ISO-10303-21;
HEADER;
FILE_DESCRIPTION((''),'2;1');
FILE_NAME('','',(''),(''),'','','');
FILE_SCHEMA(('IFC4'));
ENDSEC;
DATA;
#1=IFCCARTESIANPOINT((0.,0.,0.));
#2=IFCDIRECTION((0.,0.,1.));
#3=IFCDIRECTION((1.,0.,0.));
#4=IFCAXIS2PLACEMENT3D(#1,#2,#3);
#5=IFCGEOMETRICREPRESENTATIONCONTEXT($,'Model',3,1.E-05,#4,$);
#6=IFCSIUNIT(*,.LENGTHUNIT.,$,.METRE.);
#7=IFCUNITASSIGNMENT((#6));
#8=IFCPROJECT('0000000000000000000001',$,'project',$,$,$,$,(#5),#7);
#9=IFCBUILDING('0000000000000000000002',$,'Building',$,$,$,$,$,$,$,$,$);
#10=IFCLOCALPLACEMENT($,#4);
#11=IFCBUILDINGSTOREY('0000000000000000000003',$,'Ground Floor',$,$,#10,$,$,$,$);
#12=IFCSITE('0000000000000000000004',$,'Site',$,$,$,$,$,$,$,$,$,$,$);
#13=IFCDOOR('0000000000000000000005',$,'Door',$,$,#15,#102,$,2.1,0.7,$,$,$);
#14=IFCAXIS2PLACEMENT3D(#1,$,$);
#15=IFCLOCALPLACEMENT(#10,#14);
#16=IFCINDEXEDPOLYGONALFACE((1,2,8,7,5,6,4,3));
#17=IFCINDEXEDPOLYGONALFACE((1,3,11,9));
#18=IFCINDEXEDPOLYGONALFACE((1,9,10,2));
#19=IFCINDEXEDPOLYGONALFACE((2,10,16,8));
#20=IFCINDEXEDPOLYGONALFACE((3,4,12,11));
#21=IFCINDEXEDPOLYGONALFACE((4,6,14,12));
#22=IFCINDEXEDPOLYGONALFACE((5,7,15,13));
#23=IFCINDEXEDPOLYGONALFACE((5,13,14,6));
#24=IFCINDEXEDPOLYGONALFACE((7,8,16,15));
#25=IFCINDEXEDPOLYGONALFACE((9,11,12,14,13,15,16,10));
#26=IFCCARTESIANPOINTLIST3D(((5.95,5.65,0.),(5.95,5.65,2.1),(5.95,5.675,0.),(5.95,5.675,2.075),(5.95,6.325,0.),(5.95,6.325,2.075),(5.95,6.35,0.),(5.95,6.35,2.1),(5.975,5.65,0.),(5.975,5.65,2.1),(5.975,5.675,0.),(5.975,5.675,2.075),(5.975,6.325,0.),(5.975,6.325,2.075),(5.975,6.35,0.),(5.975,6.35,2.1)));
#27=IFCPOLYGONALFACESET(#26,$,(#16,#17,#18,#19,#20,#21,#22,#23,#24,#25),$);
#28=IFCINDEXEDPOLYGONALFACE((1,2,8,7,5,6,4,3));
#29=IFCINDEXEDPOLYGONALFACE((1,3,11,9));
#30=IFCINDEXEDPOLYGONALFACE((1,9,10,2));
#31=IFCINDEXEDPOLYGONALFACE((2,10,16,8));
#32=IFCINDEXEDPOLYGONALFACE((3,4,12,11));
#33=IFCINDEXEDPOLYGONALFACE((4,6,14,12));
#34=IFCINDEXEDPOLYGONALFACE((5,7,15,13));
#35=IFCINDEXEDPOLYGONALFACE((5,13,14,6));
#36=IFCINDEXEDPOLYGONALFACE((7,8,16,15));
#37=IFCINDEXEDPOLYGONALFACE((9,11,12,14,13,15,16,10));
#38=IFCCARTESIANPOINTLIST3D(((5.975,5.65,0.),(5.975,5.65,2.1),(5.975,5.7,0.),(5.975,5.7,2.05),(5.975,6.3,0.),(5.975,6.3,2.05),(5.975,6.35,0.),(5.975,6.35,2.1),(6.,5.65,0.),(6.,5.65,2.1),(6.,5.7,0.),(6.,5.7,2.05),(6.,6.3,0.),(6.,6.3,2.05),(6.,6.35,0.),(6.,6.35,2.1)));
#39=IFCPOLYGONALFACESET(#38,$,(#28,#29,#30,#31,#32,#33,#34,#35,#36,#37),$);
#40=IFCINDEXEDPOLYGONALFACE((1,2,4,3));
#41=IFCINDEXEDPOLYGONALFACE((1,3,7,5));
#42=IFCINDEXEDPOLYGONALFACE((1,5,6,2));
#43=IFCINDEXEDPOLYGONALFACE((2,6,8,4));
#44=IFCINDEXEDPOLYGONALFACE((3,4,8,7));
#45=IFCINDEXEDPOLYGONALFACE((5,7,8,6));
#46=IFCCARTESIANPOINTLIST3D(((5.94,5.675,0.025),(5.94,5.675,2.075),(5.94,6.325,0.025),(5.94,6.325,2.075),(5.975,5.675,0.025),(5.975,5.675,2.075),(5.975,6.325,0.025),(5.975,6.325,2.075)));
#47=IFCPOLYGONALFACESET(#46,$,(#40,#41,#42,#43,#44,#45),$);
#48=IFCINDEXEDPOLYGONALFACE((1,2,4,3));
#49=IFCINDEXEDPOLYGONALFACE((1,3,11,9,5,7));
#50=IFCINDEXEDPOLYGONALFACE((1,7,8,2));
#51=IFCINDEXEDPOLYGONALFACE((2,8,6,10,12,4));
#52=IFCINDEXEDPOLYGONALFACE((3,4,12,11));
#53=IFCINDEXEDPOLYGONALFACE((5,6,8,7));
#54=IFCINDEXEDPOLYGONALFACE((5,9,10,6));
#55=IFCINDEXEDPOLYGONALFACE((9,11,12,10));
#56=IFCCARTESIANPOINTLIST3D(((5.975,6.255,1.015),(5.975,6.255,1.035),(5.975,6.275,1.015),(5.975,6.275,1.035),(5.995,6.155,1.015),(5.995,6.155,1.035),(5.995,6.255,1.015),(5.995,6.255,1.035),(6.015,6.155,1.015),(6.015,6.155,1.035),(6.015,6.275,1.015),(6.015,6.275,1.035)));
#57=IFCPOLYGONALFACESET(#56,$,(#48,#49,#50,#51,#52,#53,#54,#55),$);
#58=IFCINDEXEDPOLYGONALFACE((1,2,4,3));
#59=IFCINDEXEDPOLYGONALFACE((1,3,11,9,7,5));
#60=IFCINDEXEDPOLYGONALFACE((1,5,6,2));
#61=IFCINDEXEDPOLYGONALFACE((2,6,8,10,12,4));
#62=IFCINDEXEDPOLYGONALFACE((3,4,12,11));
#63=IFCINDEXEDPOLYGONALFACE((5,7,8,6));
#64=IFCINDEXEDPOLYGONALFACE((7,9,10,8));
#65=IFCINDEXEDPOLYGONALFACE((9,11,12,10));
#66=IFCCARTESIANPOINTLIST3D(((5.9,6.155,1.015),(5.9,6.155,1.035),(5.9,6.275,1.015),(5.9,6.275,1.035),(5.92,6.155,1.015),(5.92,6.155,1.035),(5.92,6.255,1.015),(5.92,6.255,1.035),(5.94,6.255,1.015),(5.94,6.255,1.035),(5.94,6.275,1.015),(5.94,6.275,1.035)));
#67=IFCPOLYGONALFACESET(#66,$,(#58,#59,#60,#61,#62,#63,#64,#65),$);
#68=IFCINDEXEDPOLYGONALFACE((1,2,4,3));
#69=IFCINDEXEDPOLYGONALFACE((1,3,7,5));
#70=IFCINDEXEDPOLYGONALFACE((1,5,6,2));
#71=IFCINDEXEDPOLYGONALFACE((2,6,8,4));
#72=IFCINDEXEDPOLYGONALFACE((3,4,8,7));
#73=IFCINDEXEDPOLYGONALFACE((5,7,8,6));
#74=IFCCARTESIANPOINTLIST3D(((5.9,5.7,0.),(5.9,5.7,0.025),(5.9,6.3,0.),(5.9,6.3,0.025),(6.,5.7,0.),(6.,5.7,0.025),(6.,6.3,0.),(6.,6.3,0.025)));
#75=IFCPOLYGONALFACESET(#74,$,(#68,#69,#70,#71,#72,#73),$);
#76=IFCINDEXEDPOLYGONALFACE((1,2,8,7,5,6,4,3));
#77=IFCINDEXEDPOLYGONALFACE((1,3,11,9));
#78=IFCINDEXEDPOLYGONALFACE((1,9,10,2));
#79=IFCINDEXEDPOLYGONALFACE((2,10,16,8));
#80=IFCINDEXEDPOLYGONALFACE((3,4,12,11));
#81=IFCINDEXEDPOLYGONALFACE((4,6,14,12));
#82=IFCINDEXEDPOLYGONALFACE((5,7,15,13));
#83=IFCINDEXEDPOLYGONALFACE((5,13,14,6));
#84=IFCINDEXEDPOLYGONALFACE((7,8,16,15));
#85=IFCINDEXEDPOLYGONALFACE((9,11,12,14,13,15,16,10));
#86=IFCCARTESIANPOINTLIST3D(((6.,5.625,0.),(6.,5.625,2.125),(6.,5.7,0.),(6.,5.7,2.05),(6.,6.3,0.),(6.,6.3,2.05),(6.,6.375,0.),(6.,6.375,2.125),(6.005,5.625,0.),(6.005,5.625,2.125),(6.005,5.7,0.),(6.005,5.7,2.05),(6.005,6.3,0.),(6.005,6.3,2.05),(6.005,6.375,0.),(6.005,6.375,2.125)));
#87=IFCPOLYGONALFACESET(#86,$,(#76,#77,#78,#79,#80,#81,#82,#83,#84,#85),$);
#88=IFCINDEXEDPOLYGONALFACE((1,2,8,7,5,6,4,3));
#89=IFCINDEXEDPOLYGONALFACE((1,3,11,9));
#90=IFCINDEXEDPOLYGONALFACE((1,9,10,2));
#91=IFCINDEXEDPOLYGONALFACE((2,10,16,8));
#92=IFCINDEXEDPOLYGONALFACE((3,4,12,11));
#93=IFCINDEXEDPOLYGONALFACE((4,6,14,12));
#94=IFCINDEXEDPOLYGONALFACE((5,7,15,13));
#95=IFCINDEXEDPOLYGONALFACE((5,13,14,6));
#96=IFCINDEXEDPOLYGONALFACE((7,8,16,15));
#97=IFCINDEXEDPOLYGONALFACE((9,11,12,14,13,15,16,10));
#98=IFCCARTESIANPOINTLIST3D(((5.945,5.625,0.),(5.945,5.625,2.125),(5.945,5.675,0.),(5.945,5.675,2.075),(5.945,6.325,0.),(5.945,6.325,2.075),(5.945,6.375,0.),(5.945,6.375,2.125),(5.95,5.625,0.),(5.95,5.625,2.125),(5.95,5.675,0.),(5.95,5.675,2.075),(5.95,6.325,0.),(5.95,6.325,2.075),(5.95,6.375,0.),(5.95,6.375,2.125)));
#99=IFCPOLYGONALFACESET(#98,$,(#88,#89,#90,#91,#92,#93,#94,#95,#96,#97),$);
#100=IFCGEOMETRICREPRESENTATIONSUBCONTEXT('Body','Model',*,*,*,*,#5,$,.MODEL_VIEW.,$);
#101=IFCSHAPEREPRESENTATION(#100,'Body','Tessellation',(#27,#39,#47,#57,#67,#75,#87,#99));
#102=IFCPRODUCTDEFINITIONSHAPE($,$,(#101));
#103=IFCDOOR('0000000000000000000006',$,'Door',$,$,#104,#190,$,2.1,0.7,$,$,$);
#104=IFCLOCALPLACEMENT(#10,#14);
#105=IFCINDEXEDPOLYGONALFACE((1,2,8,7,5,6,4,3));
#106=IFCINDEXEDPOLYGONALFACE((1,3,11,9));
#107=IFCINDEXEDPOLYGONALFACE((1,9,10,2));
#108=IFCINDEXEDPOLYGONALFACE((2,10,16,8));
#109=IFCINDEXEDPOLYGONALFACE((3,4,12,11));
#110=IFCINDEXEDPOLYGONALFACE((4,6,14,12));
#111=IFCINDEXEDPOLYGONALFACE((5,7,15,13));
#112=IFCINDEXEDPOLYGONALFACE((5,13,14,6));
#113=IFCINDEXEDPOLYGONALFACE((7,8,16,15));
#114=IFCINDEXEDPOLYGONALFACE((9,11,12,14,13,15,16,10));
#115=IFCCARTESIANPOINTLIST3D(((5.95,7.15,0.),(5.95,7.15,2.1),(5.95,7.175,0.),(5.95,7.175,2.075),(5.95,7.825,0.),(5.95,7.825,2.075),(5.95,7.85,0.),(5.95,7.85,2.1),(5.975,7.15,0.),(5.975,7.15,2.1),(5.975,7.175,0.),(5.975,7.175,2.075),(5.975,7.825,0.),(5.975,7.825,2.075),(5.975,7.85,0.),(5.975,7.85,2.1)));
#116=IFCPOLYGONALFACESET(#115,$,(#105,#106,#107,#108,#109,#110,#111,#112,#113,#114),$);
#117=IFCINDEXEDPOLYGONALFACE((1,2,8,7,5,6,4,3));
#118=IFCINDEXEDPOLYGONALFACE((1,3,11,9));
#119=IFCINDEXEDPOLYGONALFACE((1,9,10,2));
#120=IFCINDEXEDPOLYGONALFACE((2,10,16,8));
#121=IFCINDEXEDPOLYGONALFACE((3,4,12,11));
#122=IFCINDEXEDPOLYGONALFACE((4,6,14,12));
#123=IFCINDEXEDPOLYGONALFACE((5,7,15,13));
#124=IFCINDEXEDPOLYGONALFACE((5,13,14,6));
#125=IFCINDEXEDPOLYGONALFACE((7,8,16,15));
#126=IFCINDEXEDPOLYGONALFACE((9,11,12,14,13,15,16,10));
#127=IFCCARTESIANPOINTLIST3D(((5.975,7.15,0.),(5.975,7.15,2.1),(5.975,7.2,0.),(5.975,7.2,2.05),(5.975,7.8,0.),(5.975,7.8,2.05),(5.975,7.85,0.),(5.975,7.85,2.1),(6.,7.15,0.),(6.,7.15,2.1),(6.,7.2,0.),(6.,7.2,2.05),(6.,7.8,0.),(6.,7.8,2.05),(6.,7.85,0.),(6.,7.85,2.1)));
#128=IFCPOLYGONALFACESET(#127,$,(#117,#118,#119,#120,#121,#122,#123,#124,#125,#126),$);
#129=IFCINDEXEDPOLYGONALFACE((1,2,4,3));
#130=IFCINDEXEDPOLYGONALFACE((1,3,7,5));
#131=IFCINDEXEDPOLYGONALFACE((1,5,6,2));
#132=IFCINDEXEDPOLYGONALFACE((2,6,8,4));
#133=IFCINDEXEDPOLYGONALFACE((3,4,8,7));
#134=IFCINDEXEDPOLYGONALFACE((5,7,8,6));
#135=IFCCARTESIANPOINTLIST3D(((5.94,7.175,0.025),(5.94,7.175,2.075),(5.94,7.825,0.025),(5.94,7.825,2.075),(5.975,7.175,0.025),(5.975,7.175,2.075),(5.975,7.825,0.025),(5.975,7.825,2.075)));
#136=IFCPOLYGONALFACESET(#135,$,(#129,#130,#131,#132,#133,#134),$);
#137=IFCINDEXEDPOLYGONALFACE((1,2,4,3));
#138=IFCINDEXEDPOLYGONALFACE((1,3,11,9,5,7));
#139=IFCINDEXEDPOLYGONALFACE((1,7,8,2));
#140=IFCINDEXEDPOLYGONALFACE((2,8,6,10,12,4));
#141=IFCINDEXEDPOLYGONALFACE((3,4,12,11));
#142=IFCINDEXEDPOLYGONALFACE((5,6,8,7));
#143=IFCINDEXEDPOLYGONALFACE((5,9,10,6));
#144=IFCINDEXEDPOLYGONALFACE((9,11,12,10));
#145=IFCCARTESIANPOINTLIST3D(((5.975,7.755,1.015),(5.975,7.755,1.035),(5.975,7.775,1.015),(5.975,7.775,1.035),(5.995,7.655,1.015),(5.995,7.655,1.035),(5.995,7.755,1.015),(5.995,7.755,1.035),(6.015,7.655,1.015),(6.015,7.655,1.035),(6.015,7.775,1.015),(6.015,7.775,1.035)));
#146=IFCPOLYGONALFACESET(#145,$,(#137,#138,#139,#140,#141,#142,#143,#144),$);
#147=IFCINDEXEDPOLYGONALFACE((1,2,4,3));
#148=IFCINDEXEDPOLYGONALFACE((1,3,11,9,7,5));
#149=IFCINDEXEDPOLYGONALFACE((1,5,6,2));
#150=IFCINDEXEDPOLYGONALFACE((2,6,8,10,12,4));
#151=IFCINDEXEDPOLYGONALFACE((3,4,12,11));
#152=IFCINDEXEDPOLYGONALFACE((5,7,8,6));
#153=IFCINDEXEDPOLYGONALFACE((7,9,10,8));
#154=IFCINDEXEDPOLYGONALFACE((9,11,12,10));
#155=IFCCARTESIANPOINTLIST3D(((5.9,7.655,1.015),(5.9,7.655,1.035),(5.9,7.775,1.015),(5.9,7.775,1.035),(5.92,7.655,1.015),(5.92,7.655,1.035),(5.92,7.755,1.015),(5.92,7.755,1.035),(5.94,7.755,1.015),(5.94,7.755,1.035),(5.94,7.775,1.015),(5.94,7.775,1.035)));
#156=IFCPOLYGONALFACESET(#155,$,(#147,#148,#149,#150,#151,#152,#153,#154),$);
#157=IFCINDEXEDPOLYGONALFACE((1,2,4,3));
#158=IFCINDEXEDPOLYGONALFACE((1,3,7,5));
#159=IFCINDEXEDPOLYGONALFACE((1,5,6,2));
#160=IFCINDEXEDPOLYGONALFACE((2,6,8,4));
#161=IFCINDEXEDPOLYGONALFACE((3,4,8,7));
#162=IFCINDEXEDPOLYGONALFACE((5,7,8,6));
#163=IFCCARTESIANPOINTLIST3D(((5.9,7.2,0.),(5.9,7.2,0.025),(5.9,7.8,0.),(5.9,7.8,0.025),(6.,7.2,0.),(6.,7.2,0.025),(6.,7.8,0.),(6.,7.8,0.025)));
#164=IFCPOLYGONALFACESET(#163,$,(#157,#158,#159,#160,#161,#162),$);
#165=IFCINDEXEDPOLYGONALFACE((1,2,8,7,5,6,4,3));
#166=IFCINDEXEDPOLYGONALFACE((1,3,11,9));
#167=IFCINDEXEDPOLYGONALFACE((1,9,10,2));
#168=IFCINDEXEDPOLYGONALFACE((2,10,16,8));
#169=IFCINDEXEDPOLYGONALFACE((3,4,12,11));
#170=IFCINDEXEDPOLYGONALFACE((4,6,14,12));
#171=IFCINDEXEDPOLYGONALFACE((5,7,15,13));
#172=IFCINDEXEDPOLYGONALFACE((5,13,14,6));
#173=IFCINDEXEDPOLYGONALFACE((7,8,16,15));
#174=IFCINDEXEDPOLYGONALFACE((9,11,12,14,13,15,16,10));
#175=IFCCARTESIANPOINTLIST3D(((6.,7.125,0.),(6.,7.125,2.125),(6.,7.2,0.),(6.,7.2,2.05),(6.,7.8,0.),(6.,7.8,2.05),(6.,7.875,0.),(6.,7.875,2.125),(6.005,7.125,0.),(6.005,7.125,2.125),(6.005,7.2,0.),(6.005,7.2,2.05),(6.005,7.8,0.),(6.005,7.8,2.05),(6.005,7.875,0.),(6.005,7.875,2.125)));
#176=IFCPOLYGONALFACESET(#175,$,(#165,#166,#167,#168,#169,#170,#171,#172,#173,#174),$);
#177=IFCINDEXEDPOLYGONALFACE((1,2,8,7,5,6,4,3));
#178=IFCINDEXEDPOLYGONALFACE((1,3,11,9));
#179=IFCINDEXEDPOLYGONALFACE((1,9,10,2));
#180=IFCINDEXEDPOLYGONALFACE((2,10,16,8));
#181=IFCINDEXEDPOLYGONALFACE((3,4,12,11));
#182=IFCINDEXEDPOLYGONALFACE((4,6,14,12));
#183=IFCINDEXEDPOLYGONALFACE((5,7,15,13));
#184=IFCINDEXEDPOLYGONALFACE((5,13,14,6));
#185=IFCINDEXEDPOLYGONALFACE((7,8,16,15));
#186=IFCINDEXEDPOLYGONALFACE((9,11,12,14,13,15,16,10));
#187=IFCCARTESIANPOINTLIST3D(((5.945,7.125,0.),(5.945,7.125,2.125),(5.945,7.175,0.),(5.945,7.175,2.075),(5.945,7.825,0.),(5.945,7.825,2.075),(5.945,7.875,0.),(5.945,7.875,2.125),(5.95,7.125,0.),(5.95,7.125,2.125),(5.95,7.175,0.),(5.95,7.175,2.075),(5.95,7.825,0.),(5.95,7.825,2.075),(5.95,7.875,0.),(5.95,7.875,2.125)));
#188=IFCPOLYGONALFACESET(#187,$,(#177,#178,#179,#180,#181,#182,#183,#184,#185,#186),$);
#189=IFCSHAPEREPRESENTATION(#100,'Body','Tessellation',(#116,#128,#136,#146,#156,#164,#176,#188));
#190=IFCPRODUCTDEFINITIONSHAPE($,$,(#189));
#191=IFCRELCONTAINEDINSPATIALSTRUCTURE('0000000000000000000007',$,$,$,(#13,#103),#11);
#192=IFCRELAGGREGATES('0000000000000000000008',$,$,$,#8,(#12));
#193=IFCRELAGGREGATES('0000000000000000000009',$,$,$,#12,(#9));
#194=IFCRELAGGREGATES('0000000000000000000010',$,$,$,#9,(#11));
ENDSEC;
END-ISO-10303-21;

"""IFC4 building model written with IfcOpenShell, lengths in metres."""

from ifc_helpers import new_model, si_unit, frame, origin_with_axes, place, context, subcontext, project, spatial, line, indexed_curve, outline, extrude, element, save


model = new_model("IFC4")

# Units and contexts
model_context = context("Model", 3, precision=1e-05, world=origin_with_axes())
body_context = subcontext(model_context, "Body", "Model", "MODEL_VIEW")
ifc_project = project(units=[si_unit("LENGTHUNIT", "METRE")], contexts=[model_context])

# Site, building, storey
site = spatial("IfcSite", under=ifc_project, Name="Site")
building = spatial("IfcBuilding", under=site, Name="Building")
storey_placement = place(None, origin_with_axes())
storey = spatial("IfcBuildingStorey", under=building, at=storey_placement, Name="Ground Floor")

# Doors
door_1_placement = place(storey_placement, frame((6.0, 5.65, 0.0), z_axis=(0.0, 0.0, 1.0), x_axis=(0.0, 1.0, 0.0)))
element("IfcDoor", 1, at=door_1_placement, inside=storey, Name="Door", OverallHeight=2.1, OverallWidth=0.7, context=body_context, shape_type="SweptSolid", body=[
    extrude(outline(indexed_curve([(0.0, 0.0), (0.0, 2.1), (0.7, 2.1), (0.7, 0.0), (0.675, 0.0), (0.675, 2.075), (0.025, 2.075), (0.025, 0.0)], segments=[line(1, 2, 3, 4, 5, 6, 7, 8, 1)])), frame((0.0, 0.025, 0.0), z_axis=(0.0, -1.0, 0.0), x_axis=(1.0, 0.0, 0.0)), (0.0, 0.0, -1.0), 0.025),
    extrude(outline(indexed_curve([(0.0, 0.0), (0.0, 2.1), (0.7, 2.1), (0.7, 0.0), (0.65, 0.0), (0.65, 2.05), (0.05, 2.05), (0.05, 0.0)], segments=[line(1, 2, 3, 4, 5, 6, 7, 8, 1)])), frame((0.0, 0.0, 0.0), z_axis=(0.0, -1.0, 0.0), x_axis=(1.0, 0.0, 0.0)), (0.0, 0.0, -1.0), 0.025),
    extrude(outline(indexed_curve([(0.0, 0.0), (0.65, 0.0), (0.65, 0.035), (0.0, 0.035)], segments=[line(1, 2, 3, 4, 1)])), frame((0.025, 0.025, 0.025), z_axis=(0.0, 0.0, 1.0), x_axis=(1.0, 0.0, 0.0)), (0.0, 0.0, 1.0), 2.05),
    extrude(outline(indexed_curve([(0.0, 0.0), (0.0, -0.04), (-0.12, -0.04), (-0.12, -0.02), (-0.02, -0.02), (-0.02, 0.0)], segments=[line(1, 2, 3, 4, 5, 6, 1)])), frame((0.625, 0.025, 1.015), z_axis=(0.0, 0.0, 1.0), x_axis=(1.0, 0.0, 0.0)), (0.0, 0.0, 1.0), 0.02),
    extrude(outline(indexed_curve([(0.0, 0.0), (0.0, 0.04), (-0.12, 0.04), (-0.12, 0.02), (-0.02, 0.02), (-0.02, 0.0)], segments=[line(1, 2, 3, 4, 5, 6, 1)])), frame((0.625, 0.06, 1.015), z_axis=(0.0, 0.0, 1.0), x_axis=(1.0, 0.0, 0.0)), (0.0, 0.0, 1.0), 0.02),
    extrude(outline(indexed_curve([(0.0, 0.0), (0.6, 0.0), (0.6, 0.1), (0.0, 0.1)], segments=[line(1, 2, 3, 4, 1)])), frame((0.05, 0.0, 0.0), z_axis=(0.0, 0.0, 1.0), x_axis=(1.0, 0.0, 0.0)), (0.0, 0.0, 1.0), 0.025),
    extrude(outline(indexed_curve([(0.0, 0.0), (0.0, 2.125), (0.75, 2.125), (0.75, 0.0), (0.675, 0.0), (0.675, 2.05), (0.075, 2.05), (0.075, 0.0)], segments=[line(1, 2, 3, 4, 5, 6, 7, 8, 1)])), frame((-0.025, -0.005, 0.0), z_axis=(0.0, -1.0, 0.0), x_axis=(1.0, 0.0, 0.0)), (0.0, 0.0, -1.0), 0.005),
    extrude(outline(indexed_curve([(0.0, 0.0), (0.0, 2.125), (0.75, 2.125), (0.75, 0.0), (0.7, 0.0), (0.7, 2.075), (0.05, 2.075), (0.05, 0.0)], segments=[line(1, 2, 3, 4, 5, 6, 7, 8, 1)])), frame((-0.025, 0.05, 0.0), z_axis=(0.0, -1.0, 0.0), x_axis=(1.0, 0.0, 0.0)), (0.0, 0.0, -1.0), 0.005),
])
door_2_placement = place(storey_placement, frame((6.0, 7.15, 0.0), z_axis=(0.0, 0.0, 1.0), x_axis=(0.0, 1.0, 0.0)))
element("IfcDoor", 2, at=door_2_placement, inside=storey, Name="Door", OverallHeight=2.1, OverallWidth=0.7, context=body_context, shape_type="SweptSolid", body=[
    extrude(outline(indexed_curve([(0.0, 0.0), (0.0, 2.1), (0.7, 2.1), (0.7, 0.0), (0.675, 0.0), (0.675, 2.075), (0.025, 2.075), (0.025, 0.0)], segments=[line(1, 2, 3, 4, 5, 6, 7, 8, 1)])), frame((0.0, 0.025, 0.0), z_axis=(0.0, -1.0, 0.0), x_axis=(1.0, 0.0, 0.0)), (0.0, 0.0, -1.0), 0.025),
    extrude(outline(indexed_curve([(0.0, 0.0), (0.0, 2.1), (0.7, 2.1), (0.7, 0.0), (0.65, 0.0), (0.65, 2.05), (0.05, 2.05), (0.05, 0.0)], segments=[line(1, 2, 3, 4, 5, 6, 7, 8, 1)])), frame((0.0, 0.0, 0.0), z_axis=(0.0, -1.0, 0.0), x_axis=(1.0, 0.0, 0.0)), (0.0, 0.0, -1.0), 0.025),
    extrude(outline(indexed_curve([(0.0, 0.0), (0.65, 0.0), (0.65, 0.035), (0.0, 0.035)], segments=[line(1, 2, 3, 4, 1)])), frame((0.025, 0.025, 0.025), z_axis=(0.0, 0.0, 1.0), x_axis=(1.0, 0.0, 0.0)), (0.0, 0.0, 1.0), 2.05),
    extrude(outline(indexed_curve([(0.0, 0.0), (0.0, -0.04), (-0.12, -0.04), (-0.12, -0.02), (-0.02, -0.02), (-0.02, 0.0)], segments=[line(1, 2, 3, 4, 5, 6, 1)])), frame((0.625, 0.025, 1.015), z_axis=(0.0, 0.0, 1.0), x_axis=(1.0, 0.0, 0.0)), (0.0, 0.0, 1.0), 0.02),
    extrude(outline(indexed_curve([(0.0, 0.0), (0.0, 0.04), (-0.12, 0.04), (-0.12, 0.02), (-0.02, 0.02), (-0.02, 0.0)], segments=[line(1, 2, 3, 4, 5, 6, 1)])), frame((0.625, 0.06, 1.015), z_axis=(0.0, 0.0, 1.0), x_axis=(1.0, 0.0, 0.0)), (0.0, 0.0, 1.0), 0.02),
    extrude(outline(indexed_curve([(0.0, 0.0), (0.6, 0.0), (0.6, 0.1), (0.0, 0.1)], segments=[line(1, 2, 3, 4, 1)])), frame((0.05, 0.0, 0.0), z_axis=(0.0, 0.0, 1.0), x_axis=(1.0, 0.0, 0.0)), (0.0, 0.0, 1.0), 0.025),
    extrude(outline(indexed_curve([(0.0, 0.0), (0.0, 2.125), (0.75, 2.125), (0.75, 0.0), (0.675, 0.0), (0.675, 2.05), (0.075, 2.05), (0.075, 0.0)], segments=[line(1, 2, 3, 4, 5, 6, 7, 8, 1)])), frame((-0.025, -0.005, 0.0), z_axis=(0.0, -1.0, 0.0), x_axis=(1.0, 0.0, 0.0)), (0.0, 0.0, -1.0), 0.005),
    extrude(outline(indexed_curve([(0.0, 0.0), (0.0, 2.125), (0.75, 2.125), (0.75, 0.0), (0.7, 0.0), (0.7, 2.075), (0.05, 2.075), (0.05, 0.0)], segments=[line(1, 2, 3, 4, 5, 6, 7, 8, 1)])), frame((-0.025, 0.05, 0.0), z_axis=(0.0, -1.0, 0.0), x_axis=(1.0, 0.0, 0.0)), (0.0, 0.0, -1.0), 0.005),
])

save(model, "model.ifc")
